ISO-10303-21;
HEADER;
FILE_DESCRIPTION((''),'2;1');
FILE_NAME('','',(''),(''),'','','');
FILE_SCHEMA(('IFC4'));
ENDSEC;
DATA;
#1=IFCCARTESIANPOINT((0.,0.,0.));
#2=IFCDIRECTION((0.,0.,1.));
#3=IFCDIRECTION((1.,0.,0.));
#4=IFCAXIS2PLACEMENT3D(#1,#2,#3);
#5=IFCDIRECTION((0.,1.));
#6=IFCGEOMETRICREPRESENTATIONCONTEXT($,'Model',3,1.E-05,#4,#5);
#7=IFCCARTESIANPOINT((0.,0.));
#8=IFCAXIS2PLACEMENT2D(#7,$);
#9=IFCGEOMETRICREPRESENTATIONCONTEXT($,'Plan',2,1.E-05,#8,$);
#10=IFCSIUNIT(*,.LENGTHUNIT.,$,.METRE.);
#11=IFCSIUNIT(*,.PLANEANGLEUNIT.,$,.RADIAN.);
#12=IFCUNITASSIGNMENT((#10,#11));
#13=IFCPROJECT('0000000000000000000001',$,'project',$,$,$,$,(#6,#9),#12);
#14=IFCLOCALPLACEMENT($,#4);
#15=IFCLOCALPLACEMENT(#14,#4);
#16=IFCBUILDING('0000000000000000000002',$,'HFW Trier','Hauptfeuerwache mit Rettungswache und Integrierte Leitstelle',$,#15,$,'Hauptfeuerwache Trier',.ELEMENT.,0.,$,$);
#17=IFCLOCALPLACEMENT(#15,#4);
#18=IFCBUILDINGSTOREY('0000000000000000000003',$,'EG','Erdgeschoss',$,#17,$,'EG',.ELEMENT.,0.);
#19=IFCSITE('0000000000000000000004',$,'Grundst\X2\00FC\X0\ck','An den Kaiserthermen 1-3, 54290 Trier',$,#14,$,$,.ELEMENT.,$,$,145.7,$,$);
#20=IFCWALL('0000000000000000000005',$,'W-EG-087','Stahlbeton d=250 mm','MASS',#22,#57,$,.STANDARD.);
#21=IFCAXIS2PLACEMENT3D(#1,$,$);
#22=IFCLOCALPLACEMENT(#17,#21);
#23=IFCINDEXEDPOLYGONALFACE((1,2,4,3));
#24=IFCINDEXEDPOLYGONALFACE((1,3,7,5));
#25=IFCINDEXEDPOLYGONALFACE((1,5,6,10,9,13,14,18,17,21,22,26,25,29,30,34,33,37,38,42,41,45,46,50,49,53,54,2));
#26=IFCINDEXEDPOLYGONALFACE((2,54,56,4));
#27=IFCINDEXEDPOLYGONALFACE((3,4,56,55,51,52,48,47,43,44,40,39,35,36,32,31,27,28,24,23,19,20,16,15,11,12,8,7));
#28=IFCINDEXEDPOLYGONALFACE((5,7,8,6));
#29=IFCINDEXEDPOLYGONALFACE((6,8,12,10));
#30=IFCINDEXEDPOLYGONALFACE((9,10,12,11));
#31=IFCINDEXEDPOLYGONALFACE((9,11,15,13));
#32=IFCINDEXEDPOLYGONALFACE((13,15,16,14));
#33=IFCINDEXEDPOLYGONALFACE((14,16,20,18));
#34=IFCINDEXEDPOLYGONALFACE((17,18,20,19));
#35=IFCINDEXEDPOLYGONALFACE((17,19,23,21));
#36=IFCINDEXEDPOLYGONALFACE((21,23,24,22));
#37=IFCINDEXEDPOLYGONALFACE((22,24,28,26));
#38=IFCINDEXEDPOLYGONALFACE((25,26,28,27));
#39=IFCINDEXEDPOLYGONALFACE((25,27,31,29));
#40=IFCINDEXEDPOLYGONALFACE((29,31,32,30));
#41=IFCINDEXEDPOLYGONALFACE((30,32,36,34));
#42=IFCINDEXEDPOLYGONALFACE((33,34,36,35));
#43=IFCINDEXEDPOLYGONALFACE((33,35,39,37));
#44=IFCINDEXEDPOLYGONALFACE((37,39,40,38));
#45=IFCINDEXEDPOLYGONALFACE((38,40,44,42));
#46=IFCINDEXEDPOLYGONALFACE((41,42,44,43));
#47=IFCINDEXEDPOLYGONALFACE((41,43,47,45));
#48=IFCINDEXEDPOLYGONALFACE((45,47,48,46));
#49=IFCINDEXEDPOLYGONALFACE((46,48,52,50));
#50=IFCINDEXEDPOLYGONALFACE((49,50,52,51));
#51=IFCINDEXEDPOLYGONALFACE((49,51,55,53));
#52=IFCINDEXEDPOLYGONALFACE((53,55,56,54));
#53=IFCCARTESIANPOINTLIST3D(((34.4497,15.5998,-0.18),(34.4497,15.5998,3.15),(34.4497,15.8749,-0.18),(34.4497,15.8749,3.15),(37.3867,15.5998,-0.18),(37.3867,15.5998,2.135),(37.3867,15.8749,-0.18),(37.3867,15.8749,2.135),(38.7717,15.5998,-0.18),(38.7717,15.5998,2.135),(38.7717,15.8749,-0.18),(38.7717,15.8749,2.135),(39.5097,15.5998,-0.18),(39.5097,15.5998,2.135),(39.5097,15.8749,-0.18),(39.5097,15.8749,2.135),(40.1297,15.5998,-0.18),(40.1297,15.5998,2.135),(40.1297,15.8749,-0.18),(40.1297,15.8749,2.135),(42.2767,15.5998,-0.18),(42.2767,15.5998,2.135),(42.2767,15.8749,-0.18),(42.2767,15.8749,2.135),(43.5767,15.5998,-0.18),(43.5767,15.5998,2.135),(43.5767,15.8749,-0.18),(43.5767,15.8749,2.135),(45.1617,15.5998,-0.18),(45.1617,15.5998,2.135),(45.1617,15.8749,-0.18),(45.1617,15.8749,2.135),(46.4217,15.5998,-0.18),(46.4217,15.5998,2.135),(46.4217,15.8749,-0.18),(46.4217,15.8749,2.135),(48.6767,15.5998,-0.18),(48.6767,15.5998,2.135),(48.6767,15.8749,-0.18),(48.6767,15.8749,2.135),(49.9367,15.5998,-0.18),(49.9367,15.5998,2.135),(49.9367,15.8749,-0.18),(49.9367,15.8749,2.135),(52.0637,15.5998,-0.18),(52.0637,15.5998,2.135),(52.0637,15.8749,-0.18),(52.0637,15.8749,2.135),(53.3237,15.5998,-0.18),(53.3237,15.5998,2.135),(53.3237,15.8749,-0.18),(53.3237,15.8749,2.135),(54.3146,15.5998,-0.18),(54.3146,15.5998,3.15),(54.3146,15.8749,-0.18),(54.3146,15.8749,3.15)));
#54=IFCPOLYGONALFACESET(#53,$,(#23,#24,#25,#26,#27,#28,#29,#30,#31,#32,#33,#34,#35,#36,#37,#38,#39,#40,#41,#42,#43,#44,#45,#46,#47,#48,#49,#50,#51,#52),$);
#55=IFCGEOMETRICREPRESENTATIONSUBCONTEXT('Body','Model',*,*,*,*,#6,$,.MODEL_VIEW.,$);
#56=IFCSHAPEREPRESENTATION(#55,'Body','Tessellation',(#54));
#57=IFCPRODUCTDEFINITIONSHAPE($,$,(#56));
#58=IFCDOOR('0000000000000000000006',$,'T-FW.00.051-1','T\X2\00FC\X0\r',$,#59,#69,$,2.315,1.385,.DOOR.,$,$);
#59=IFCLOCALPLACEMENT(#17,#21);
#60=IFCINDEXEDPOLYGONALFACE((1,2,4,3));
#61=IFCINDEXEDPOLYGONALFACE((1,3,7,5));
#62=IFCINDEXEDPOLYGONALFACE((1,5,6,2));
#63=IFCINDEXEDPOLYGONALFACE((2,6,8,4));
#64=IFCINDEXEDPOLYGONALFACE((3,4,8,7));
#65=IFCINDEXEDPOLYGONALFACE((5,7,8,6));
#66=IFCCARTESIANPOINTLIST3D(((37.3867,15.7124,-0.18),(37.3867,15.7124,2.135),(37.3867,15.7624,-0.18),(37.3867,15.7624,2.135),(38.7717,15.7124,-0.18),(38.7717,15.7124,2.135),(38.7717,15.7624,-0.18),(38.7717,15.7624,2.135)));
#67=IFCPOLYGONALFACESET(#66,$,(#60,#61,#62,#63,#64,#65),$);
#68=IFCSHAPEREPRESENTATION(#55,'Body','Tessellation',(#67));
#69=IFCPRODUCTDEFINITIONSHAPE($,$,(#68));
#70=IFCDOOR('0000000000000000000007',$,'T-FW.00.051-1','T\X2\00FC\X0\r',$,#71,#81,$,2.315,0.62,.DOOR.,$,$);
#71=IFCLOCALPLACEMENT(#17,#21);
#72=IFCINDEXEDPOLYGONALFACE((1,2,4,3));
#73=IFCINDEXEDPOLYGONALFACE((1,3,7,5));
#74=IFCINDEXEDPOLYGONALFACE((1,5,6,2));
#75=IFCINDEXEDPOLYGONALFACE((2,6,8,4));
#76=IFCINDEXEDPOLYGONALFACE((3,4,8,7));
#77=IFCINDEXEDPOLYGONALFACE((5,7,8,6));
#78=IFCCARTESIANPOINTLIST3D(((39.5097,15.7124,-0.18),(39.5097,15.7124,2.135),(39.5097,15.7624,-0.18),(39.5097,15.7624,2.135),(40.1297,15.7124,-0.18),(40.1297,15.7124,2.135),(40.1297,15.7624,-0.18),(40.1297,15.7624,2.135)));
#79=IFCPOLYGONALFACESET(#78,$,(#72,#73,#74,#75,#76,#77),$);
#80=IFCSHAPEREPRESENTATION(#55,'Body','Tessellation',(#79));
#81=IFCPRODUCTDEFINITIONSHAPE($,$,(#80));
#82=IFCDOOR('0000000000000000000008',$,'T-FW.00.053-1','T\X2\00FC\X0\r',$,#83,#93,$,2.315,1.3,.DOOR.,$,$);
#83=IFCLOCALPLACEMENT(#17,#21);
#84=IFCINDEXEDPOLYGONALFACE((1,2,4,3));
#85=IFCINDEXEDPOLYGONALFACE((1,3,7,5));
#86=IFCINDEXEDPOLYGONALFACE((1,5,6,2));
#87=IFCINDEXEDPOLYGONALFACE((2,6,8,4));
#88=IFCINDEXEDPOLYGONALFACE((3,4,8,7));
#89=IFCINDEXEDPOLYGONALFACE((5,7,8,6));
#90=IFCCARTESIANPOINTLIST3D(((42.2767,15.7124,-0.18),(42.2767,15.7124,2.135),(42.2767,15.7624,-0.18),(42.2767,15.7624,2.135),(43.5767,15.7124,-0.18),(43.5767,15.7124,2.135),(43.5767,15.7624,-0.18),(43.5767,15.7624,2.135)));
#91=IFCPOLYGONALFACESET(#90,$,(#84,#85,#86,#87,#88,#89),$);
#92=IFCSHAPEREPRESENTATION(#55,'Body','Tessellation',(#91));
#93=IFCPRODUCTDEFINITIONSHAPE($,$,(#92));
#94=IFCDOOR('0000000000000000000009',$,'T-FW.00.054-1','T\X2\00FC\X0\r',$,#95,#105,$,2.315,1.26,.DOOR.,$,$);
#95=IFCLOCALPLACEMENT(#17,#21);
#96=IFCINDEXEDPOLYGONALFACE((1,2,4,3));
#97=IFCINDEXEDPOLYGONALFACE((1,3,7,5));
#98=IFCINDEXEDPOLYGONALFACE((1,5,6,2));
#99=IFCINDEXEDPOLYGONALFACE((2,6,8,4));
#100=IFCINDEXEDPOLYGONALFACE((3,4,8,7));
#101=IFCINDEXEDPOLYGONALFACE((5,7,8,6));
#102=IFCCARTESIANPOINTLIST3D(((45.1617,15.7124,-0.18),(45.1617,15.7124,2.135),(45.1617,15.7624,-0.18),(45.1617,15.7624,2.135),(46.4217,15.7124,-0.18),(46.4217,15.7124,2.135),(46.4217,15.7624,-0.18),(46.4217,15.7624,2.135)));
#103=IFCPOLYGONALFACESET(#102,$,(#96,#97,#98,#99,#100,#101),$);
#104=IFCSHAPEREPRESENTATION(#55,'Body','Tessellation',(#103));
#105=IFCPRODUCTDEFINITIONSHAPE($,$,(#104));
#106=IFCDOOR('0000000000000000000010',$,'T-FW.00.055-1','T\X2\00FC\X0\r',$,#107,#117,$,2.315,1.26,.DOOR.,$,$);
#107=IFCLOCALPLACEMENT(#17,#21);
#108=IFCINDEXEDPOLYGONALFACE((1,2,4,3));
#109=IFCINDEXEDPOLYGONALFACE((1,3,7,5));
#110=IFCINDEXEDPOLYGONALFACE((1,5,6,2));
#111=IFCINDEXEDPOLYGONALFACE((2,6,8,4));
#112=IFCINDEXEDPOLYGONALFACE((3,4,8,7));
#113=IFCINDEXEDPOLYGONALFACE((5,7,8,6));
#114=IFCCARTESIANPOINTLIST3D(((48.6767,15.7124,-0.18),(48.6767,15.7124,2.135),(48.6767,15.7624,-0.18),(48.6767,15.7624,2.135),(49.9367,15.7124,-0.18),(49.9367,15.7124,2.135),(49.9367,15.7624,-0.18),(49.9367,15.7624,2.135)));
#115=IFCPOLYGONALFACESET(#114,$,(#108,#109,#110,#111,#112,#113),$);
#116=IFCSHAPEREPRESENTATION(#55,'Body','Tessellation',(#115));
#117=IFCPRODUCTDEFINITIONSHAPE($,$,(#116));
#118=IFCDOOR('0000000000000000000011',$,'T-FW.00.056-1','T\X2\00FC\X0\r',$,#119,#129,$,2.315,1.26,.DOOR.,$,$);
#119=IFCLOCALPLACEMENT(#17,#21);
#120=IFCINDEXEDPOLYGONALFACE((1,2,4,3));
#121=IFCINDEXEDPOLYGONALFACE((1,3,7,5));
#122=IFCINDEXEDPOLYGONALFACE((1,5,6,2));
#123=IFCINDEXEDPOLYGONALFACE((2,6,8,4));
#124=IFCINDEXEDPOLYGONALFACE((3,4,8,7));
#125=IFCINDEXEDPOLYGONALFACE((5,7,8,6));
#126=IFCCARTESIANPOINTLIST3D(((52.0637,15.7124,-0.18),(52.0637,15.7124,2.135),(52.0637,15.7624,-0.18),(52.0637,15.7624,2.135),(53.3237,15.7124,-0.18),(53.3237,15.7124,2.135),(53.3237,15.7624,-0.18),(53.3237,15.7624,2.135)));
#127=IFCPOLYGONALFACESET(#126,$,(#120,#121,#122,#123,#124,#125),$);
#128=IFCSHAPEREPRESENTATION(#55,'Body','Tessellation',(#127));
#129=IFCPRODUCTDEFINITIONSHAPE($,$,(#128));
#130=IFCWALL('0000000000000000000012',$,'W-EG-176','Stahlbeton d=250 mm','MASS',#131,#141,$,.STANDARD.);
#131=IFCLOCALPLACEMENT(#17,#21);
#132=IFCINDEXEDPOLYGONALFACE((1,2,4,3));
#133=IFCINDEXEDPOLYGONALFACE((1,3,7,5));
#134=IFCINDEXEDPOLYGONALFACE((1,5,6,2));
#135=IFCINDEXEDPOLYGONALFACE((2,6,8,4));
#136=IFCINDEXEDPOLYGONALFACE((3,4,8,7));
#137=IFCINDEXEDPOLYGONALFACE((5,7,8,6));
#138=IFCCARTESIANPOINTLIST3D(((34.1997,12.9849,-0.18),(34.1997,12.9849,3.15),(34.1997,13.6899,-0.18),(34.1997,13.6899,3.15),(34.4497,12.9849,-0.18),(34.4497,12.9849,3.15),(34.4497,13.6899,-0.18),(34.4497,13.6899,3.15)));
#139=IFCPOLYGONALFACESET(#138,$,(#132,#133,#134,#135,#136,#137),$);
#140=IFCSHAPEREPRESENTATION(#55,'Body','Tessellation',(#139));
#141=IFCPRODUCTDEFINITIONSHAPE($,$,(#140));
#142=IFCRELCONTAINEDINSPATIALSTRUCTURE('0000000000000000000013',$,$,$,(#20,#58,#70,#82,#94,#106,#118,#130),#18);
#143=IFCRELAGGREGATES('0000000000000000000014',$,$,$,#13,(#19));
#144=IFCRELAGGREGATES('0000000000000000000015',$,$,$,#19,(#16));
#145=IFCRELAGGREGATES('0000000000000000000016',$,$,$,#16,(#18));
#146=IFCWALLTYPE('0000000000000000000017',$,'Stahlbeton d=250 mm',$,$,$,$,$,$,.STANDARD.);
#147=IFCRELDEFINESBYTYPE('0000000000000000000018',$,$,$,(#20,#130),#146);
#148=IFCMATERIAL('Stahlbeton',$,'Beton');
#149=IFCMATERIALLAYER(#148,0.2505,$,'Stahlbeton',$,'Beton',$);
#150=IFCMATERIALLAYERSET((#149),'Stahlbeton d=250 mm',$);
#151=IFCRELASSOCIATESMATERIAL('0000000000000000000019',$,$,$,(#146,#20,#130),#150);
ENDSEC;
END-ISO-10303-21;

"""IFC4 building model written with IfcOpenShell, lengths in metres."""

from ifc_helpers import new_model, si_unit, direction, frame, frame_2d, origin_with_axes, origin_2d, place, context, subcontext, project, spatial, rectangle, extrude, material, layer, layer_set, layer_usage, type_object, element, fill, save


model = new_model("IFC4")

# Units and contexts
model_context = context("Model", 3, precision=1e-05, world=origin_with_axes(), true_north=direction((0.0, 1.0)))
plan_context = context("Plan", 2, precision=1e-05, world=origin_2d())
body_context = subcontext(model_context, "Body", "Model", "MODEL_VIEW")
ifc_project = project(units=[si_unit("LENGTHUNIT", "METRE"), si_unit("PLANEANGLEUNIT", "RADIAN")], contexts=[model_context, plan_context])

# Site, building, storey
site_placement = place(None, origin_with_axes())
site = spatial("IfcSite", under=ifc_project, at=site_placement, Name="Grundstück", Description="An den Kaiserthermen 1-3, 54290 Trier", CompositionType="ELEMENT", RefElevation=145.7)
building_placement = place(site_placement, origin_with_axes())
building = spatial("IfcBuilding", under=site, at=building_placement, Name="HFW Trier", Description="Hauptfeuerwache mit Rettungswache und Integrierte Leitstelle", LongName="Hauptfeuerwache Trier", CompositionType="ELEMENT", ElevationOfRefHeight=0.0)
storey_placement = place(building_placement, origin_with_axes())
storey = spatial("IfcBuildingStorey", under=building, at=storey_placement, Name="EG", Description="Erdgeschoss", LongName="EG", CompositionType="ELEMENT", Elevation=0.0)

# Wall, openings, doors
ifc_material_1 = material(Name="Stahlbeton", Category="Beton")
ifc_layer_1 = layer(ifc_material_1, 0.2505, Name="Stahlbeton", Category="Beton")
ifc_layer_set_1 = layer_set([ifc_layer_1], Name="Stahlbeton d=250 mm")
ifc_layer_usage_1 = layer_usage(ifc_layer_set_1, "AXIS2", "POSITIVE", -0.1376)
wall_type_1 = type_object("IfcWallType", Name="Stahlbeton d=250 mm", PredefinedType="STANDARD", material=ifc_layer_set_1)
wall_1_placement = place(storey_placement, frame((34.4497, 15.7374, -0.18), z_axis=(0.0, 0.0, 1.0), x_axis=(1.0, 0.0, 0.0)))
wall_1 = element("IfcWall", 1, at=wall_1_placement, inside=storey, type_object=wall_type_1, material=ifc_layer_usage_1, Name="W-EG-087", Description="Stahlbeton d=250 mm", ObjectType="MASS", PredefinedType="STANDARD", context=body_context, shape_type="SweptSolid", body=[
    extrude(rectangle(XDim=19.8649, YDim=0.2751, at=frame_2d((9.9324, 0.0))), origin_with_axes(), (0.0, 0.0, 1.0), 3.33),
])
opening_1_placement = place(wall_1_placement, frame((2.937, 0.0, 0.0), z_axis=(0.0, 0.0, 1.0), x_axis=(1.0, 0.0, 0.0)))
opening_1 = element("IfcOpeningElement", 2, at=opening_1_placement, cuts=wall_1, PredefinedType="OPENING", context=body_context, shape_type="SweptSolid", body=[
    extrude(rectangle(XDim=1.385, YDim=0.3751, at=frame_2d((0.6925, 0.0))), origin_with_axes(), (0.0, 0.0, 1.0), 2.315),
])
opening_2_placement = place(wall_1_placement, frame((5.06, 0.0, 0.0), z_axis=(0.0, 0.0, 1.0), x_axis=(1.0, 0.0, 0.0)))
opening_2 = element("IfcOpeningElement", 3, at=opening_2_placement, cuts=wall_1, PredefinedType="OPENING", context=body_context, shape_type="SweptSolid", body=[
    extrude(rectangle(XDim=0.62, YDim=0.3751, at=frame_2d((0.31, 0.0))), origin_with_axes(), (0.0, 0.0, 1.0), 2.315),
])
opening_3_placement = place(wall_1_placement, frame((7.827, 0.0, 0.0), z_axis=(0.0, 0.0, 1.0), x_axis=(1.0, 0.0, 0.0)))
opening_3 = element("IfcOpeningElement", 4, at=opening_3_placement, cuts=wall_1, PredefinedType="OPENING", context=body_context, shape_type="SweptSolid", body=[
    extrude(rectangle(XDim=1.3, YDim=0.3751, at=frame_2d((0.65, 0.0))), origin_with_axes(), (0.0, 0.0, 1.0), 2.315),
])
opening_4_placement = place(wall_1_placement, frame((10.712, 0.0, 0.0), z_axis=(0.0, 0.0, 1.0), x_axis=(1.0, 0.0, 0.0)))
opening_4 = element("IfcOpeningElement", 5, at=opening_4_placement, cuts=wall_1, PredefinedType="OPENING", context=body_context, shape_type="SweptSolid", body=[
    extrude(rectangle(XDim=1.26, YDim=0.3751, at=frame_2d((0.63, 0.0))), origin_with_axes(), (0.0, 0.0, 1.0), 2.315),
])
opening_5_placement = place(wall_1_placement, frame((14.227, 0.0, 0.0), z_axis=(0.0, 0.0, 1.0), x_axis=(1.0, 0.0, 0.0)))
opening_5 = element("IfcOpeningElement", 6, at=opening_5_placement, cuts=wall_1, PredefinedType="OPENING", context=body_context, shape_type="SweptSolid", body=[
    extrude(rectangle(XDim=1.26, YDim=0.3751, at=frame_2d((0.63, 0.0))), origin_with_axes(), (0.0, 0.0, 1.0), 2.315),
])
opening_6_placement = place(wall_1_placement, frame((17.614, 0.0, 0.0), z_axis=(0.0, 0.0, 1.0), x_axis=(1.0, 0.0, 0.0)))
opening_6 = element("IfcOpeningElement", 7, at=opening_6_placement, cuts=wall_1, PredefinedType="OPENING", context=body_context, shape_type="SweptSolid", body=[
    extrude(rectangle(XDim=1.26, YDim=0.3751, at=frame_2d((0.63, 0.0))), origin_with_axes(), (0.0, 0.0, 1.0), 2.315),
])
door_1_placement = place(wall_1_placement, frame((2.937, 0.0, 0.0), z_axis=(0.0, 0.0, 1.0), x_axis=(1.0, 0.0, 0.0)))
door_1 = element("IfcDoor", 8, at=door_1_placement, inside=storey, Name="T-FW.00.051-1", Description="Tür", OverallHeight=2.315, OverallWidth=1.385, PredefinedType="DOOR", context=body_context, shape_type="SweptSolid", body=[
    extrude(rectangle(XDim=1.385, YDim=0.05, at=frame_2d((0.6925, 0.0))), origin_with_axes(), (0.0, 0.0, 1.0), 2.315),
])
fill(opening_1, door_1)
door_2_placement = place(wall_1_placement, frame((5.06, 0.0, 0.0), z_axis=(0.0, 0.0, 1.0), x_axis=(1.0, 0.0, 0.0)))
door_2 = element("IfcDoor", 9, at=door_2_placement, inside=storey, Name="T-FW.00.051-1", Description="Tür", OverallHeight=2.315, OverallWidth=0.62, PredefinedType="DOOR", context=body_context, shape_type="SweptSolid", body=[
    extrude(rectangle(XDim=0.62, YDim=0.05, at=frame_2d((0.31, 0.0))), origin_with_axes(), (0.0, 0.0, 1.0), 2.315),
])
fill(opening_2, door_2)
door_3_placement = place(wall_1_placement, frame((7.827, 0.0, 0.0), z_axis=(0.0, 0.0, 1.0), x_axis=(1.0, 0.0, 0.0)))
door_3 = element("IfcDoor", 10, at=door_3_placement, inside=storey, Name="T-FW.00.053-1", Description="Tür", OverallHeight=2.315, OverallWidth=1.3, PredefinedType="DOOR", context=body_context, shape_type="SweptSolid", body=[
    extrude(rectangle(XDim=1.3, YDim=0.05, at=frame_2d((0.65, 0.0))), origin_with_axes(), (0.0, 0.0, 1.0), 2.315),
])
fill(opening_3, door_3)
door_4_placement = place(wall_1_placement, frame((10.712, 0.0, 0.0), z_axis=(0.0, 0.0, 1.0), x_axis=(1.0, 0.0, 0.0)))
door_4 = element("IfcDoor", 11, at=door_4_placement, inside=storey, Name="T-FW.00.054-1", Description="Tür", OverallHeight=2.315, OverallWidth=1.26, PredefinedType="DOOR", context=body_context, shape_type="SweptSolid", body=[
    extrude(rectangle(XDim=1.26, YDim=0.05, at=frame_2d((0.63, 0.0))), origin_with_axes(), (0.0, 0.0, 1.0), 2.315),
])
fill(opening_4, door_4)
door_5_placement = place(wall_1_placement, frame((14.227, 0.0, 0.0), z_axis=(0.0, 0.0, 1.0), x_axis=(1.0, 0.0, 0.0)))
door_5 = element("IfcDoor", 12, at=door_5_placement, inside=storey, Name="T-FW.00.055-1", Description="Tür", OverallHeight=2.315, OverallWidth=1.26, PredefinedType="DOOR", context=body_context, shape_type="SweptSolid", body=[
    extrude(rectangle(XDim=1.26, YDim=0.05, at=frame_2d((0.63, 0.0))), origin_with_axes(), (0.0, 0.0, 1.0), 2.315),
])
fill(opening_5, door_5)
door_6_placement = place(wall_1_placement, frame((17.614, 0.0, 0.0), z_axis=(0.0, 0.0, 1.0), x_axis=(1.0, 0.0, 0.0)))
door_6 = element("IfcDoor", 13, at=door_6_placement, inside=storey, Name="T-FW.00.056-1", Description="Tür", OverallHeight=2.315, OverallWidth=1.26, PredefinedType="DOOR", context=body_context, shape_type="SweptSolid", body=[
    extrude(rectangle(XDim=1.26, YDim=0.05, at=frame_2d((0.63, 0.0))), origin_with_axes(), (0.0, 0.0, 1.0), 2.315),
])
fill(opening_6, door_6)

# Wall
ifc_layer_usage_2 = layer_usage(ifc_layer_set_1, "AXIS2", "POSITIVE", -0.125)
wall_2_placement = place(storey_placement, frame((34.3247, 13.6899, -0.18), z_axis=(0.0, 0.0, 1.0), x_axis=(0.0, -1.0, 0.0)))
element("IfcWall", 14, at=wall_2_placement, inside=storey, type_object=wall_type_1, material=ifc_layer_usage_2, Name="W-EG-176", Description="Stahlbeton d=250 mm", ObjectType="MASS", PredefinedType="STANDARD", context=body_context, shape_type="SweptSolid", body=[
    extrude(rectangle(XDim=0.705, YDim=0.25, at=frame_2d((0.3525, 0.0))), origin_with_axes(), (0.0, 0.0, 1.0), 3.33),
])

save(model, "model.ifc")
